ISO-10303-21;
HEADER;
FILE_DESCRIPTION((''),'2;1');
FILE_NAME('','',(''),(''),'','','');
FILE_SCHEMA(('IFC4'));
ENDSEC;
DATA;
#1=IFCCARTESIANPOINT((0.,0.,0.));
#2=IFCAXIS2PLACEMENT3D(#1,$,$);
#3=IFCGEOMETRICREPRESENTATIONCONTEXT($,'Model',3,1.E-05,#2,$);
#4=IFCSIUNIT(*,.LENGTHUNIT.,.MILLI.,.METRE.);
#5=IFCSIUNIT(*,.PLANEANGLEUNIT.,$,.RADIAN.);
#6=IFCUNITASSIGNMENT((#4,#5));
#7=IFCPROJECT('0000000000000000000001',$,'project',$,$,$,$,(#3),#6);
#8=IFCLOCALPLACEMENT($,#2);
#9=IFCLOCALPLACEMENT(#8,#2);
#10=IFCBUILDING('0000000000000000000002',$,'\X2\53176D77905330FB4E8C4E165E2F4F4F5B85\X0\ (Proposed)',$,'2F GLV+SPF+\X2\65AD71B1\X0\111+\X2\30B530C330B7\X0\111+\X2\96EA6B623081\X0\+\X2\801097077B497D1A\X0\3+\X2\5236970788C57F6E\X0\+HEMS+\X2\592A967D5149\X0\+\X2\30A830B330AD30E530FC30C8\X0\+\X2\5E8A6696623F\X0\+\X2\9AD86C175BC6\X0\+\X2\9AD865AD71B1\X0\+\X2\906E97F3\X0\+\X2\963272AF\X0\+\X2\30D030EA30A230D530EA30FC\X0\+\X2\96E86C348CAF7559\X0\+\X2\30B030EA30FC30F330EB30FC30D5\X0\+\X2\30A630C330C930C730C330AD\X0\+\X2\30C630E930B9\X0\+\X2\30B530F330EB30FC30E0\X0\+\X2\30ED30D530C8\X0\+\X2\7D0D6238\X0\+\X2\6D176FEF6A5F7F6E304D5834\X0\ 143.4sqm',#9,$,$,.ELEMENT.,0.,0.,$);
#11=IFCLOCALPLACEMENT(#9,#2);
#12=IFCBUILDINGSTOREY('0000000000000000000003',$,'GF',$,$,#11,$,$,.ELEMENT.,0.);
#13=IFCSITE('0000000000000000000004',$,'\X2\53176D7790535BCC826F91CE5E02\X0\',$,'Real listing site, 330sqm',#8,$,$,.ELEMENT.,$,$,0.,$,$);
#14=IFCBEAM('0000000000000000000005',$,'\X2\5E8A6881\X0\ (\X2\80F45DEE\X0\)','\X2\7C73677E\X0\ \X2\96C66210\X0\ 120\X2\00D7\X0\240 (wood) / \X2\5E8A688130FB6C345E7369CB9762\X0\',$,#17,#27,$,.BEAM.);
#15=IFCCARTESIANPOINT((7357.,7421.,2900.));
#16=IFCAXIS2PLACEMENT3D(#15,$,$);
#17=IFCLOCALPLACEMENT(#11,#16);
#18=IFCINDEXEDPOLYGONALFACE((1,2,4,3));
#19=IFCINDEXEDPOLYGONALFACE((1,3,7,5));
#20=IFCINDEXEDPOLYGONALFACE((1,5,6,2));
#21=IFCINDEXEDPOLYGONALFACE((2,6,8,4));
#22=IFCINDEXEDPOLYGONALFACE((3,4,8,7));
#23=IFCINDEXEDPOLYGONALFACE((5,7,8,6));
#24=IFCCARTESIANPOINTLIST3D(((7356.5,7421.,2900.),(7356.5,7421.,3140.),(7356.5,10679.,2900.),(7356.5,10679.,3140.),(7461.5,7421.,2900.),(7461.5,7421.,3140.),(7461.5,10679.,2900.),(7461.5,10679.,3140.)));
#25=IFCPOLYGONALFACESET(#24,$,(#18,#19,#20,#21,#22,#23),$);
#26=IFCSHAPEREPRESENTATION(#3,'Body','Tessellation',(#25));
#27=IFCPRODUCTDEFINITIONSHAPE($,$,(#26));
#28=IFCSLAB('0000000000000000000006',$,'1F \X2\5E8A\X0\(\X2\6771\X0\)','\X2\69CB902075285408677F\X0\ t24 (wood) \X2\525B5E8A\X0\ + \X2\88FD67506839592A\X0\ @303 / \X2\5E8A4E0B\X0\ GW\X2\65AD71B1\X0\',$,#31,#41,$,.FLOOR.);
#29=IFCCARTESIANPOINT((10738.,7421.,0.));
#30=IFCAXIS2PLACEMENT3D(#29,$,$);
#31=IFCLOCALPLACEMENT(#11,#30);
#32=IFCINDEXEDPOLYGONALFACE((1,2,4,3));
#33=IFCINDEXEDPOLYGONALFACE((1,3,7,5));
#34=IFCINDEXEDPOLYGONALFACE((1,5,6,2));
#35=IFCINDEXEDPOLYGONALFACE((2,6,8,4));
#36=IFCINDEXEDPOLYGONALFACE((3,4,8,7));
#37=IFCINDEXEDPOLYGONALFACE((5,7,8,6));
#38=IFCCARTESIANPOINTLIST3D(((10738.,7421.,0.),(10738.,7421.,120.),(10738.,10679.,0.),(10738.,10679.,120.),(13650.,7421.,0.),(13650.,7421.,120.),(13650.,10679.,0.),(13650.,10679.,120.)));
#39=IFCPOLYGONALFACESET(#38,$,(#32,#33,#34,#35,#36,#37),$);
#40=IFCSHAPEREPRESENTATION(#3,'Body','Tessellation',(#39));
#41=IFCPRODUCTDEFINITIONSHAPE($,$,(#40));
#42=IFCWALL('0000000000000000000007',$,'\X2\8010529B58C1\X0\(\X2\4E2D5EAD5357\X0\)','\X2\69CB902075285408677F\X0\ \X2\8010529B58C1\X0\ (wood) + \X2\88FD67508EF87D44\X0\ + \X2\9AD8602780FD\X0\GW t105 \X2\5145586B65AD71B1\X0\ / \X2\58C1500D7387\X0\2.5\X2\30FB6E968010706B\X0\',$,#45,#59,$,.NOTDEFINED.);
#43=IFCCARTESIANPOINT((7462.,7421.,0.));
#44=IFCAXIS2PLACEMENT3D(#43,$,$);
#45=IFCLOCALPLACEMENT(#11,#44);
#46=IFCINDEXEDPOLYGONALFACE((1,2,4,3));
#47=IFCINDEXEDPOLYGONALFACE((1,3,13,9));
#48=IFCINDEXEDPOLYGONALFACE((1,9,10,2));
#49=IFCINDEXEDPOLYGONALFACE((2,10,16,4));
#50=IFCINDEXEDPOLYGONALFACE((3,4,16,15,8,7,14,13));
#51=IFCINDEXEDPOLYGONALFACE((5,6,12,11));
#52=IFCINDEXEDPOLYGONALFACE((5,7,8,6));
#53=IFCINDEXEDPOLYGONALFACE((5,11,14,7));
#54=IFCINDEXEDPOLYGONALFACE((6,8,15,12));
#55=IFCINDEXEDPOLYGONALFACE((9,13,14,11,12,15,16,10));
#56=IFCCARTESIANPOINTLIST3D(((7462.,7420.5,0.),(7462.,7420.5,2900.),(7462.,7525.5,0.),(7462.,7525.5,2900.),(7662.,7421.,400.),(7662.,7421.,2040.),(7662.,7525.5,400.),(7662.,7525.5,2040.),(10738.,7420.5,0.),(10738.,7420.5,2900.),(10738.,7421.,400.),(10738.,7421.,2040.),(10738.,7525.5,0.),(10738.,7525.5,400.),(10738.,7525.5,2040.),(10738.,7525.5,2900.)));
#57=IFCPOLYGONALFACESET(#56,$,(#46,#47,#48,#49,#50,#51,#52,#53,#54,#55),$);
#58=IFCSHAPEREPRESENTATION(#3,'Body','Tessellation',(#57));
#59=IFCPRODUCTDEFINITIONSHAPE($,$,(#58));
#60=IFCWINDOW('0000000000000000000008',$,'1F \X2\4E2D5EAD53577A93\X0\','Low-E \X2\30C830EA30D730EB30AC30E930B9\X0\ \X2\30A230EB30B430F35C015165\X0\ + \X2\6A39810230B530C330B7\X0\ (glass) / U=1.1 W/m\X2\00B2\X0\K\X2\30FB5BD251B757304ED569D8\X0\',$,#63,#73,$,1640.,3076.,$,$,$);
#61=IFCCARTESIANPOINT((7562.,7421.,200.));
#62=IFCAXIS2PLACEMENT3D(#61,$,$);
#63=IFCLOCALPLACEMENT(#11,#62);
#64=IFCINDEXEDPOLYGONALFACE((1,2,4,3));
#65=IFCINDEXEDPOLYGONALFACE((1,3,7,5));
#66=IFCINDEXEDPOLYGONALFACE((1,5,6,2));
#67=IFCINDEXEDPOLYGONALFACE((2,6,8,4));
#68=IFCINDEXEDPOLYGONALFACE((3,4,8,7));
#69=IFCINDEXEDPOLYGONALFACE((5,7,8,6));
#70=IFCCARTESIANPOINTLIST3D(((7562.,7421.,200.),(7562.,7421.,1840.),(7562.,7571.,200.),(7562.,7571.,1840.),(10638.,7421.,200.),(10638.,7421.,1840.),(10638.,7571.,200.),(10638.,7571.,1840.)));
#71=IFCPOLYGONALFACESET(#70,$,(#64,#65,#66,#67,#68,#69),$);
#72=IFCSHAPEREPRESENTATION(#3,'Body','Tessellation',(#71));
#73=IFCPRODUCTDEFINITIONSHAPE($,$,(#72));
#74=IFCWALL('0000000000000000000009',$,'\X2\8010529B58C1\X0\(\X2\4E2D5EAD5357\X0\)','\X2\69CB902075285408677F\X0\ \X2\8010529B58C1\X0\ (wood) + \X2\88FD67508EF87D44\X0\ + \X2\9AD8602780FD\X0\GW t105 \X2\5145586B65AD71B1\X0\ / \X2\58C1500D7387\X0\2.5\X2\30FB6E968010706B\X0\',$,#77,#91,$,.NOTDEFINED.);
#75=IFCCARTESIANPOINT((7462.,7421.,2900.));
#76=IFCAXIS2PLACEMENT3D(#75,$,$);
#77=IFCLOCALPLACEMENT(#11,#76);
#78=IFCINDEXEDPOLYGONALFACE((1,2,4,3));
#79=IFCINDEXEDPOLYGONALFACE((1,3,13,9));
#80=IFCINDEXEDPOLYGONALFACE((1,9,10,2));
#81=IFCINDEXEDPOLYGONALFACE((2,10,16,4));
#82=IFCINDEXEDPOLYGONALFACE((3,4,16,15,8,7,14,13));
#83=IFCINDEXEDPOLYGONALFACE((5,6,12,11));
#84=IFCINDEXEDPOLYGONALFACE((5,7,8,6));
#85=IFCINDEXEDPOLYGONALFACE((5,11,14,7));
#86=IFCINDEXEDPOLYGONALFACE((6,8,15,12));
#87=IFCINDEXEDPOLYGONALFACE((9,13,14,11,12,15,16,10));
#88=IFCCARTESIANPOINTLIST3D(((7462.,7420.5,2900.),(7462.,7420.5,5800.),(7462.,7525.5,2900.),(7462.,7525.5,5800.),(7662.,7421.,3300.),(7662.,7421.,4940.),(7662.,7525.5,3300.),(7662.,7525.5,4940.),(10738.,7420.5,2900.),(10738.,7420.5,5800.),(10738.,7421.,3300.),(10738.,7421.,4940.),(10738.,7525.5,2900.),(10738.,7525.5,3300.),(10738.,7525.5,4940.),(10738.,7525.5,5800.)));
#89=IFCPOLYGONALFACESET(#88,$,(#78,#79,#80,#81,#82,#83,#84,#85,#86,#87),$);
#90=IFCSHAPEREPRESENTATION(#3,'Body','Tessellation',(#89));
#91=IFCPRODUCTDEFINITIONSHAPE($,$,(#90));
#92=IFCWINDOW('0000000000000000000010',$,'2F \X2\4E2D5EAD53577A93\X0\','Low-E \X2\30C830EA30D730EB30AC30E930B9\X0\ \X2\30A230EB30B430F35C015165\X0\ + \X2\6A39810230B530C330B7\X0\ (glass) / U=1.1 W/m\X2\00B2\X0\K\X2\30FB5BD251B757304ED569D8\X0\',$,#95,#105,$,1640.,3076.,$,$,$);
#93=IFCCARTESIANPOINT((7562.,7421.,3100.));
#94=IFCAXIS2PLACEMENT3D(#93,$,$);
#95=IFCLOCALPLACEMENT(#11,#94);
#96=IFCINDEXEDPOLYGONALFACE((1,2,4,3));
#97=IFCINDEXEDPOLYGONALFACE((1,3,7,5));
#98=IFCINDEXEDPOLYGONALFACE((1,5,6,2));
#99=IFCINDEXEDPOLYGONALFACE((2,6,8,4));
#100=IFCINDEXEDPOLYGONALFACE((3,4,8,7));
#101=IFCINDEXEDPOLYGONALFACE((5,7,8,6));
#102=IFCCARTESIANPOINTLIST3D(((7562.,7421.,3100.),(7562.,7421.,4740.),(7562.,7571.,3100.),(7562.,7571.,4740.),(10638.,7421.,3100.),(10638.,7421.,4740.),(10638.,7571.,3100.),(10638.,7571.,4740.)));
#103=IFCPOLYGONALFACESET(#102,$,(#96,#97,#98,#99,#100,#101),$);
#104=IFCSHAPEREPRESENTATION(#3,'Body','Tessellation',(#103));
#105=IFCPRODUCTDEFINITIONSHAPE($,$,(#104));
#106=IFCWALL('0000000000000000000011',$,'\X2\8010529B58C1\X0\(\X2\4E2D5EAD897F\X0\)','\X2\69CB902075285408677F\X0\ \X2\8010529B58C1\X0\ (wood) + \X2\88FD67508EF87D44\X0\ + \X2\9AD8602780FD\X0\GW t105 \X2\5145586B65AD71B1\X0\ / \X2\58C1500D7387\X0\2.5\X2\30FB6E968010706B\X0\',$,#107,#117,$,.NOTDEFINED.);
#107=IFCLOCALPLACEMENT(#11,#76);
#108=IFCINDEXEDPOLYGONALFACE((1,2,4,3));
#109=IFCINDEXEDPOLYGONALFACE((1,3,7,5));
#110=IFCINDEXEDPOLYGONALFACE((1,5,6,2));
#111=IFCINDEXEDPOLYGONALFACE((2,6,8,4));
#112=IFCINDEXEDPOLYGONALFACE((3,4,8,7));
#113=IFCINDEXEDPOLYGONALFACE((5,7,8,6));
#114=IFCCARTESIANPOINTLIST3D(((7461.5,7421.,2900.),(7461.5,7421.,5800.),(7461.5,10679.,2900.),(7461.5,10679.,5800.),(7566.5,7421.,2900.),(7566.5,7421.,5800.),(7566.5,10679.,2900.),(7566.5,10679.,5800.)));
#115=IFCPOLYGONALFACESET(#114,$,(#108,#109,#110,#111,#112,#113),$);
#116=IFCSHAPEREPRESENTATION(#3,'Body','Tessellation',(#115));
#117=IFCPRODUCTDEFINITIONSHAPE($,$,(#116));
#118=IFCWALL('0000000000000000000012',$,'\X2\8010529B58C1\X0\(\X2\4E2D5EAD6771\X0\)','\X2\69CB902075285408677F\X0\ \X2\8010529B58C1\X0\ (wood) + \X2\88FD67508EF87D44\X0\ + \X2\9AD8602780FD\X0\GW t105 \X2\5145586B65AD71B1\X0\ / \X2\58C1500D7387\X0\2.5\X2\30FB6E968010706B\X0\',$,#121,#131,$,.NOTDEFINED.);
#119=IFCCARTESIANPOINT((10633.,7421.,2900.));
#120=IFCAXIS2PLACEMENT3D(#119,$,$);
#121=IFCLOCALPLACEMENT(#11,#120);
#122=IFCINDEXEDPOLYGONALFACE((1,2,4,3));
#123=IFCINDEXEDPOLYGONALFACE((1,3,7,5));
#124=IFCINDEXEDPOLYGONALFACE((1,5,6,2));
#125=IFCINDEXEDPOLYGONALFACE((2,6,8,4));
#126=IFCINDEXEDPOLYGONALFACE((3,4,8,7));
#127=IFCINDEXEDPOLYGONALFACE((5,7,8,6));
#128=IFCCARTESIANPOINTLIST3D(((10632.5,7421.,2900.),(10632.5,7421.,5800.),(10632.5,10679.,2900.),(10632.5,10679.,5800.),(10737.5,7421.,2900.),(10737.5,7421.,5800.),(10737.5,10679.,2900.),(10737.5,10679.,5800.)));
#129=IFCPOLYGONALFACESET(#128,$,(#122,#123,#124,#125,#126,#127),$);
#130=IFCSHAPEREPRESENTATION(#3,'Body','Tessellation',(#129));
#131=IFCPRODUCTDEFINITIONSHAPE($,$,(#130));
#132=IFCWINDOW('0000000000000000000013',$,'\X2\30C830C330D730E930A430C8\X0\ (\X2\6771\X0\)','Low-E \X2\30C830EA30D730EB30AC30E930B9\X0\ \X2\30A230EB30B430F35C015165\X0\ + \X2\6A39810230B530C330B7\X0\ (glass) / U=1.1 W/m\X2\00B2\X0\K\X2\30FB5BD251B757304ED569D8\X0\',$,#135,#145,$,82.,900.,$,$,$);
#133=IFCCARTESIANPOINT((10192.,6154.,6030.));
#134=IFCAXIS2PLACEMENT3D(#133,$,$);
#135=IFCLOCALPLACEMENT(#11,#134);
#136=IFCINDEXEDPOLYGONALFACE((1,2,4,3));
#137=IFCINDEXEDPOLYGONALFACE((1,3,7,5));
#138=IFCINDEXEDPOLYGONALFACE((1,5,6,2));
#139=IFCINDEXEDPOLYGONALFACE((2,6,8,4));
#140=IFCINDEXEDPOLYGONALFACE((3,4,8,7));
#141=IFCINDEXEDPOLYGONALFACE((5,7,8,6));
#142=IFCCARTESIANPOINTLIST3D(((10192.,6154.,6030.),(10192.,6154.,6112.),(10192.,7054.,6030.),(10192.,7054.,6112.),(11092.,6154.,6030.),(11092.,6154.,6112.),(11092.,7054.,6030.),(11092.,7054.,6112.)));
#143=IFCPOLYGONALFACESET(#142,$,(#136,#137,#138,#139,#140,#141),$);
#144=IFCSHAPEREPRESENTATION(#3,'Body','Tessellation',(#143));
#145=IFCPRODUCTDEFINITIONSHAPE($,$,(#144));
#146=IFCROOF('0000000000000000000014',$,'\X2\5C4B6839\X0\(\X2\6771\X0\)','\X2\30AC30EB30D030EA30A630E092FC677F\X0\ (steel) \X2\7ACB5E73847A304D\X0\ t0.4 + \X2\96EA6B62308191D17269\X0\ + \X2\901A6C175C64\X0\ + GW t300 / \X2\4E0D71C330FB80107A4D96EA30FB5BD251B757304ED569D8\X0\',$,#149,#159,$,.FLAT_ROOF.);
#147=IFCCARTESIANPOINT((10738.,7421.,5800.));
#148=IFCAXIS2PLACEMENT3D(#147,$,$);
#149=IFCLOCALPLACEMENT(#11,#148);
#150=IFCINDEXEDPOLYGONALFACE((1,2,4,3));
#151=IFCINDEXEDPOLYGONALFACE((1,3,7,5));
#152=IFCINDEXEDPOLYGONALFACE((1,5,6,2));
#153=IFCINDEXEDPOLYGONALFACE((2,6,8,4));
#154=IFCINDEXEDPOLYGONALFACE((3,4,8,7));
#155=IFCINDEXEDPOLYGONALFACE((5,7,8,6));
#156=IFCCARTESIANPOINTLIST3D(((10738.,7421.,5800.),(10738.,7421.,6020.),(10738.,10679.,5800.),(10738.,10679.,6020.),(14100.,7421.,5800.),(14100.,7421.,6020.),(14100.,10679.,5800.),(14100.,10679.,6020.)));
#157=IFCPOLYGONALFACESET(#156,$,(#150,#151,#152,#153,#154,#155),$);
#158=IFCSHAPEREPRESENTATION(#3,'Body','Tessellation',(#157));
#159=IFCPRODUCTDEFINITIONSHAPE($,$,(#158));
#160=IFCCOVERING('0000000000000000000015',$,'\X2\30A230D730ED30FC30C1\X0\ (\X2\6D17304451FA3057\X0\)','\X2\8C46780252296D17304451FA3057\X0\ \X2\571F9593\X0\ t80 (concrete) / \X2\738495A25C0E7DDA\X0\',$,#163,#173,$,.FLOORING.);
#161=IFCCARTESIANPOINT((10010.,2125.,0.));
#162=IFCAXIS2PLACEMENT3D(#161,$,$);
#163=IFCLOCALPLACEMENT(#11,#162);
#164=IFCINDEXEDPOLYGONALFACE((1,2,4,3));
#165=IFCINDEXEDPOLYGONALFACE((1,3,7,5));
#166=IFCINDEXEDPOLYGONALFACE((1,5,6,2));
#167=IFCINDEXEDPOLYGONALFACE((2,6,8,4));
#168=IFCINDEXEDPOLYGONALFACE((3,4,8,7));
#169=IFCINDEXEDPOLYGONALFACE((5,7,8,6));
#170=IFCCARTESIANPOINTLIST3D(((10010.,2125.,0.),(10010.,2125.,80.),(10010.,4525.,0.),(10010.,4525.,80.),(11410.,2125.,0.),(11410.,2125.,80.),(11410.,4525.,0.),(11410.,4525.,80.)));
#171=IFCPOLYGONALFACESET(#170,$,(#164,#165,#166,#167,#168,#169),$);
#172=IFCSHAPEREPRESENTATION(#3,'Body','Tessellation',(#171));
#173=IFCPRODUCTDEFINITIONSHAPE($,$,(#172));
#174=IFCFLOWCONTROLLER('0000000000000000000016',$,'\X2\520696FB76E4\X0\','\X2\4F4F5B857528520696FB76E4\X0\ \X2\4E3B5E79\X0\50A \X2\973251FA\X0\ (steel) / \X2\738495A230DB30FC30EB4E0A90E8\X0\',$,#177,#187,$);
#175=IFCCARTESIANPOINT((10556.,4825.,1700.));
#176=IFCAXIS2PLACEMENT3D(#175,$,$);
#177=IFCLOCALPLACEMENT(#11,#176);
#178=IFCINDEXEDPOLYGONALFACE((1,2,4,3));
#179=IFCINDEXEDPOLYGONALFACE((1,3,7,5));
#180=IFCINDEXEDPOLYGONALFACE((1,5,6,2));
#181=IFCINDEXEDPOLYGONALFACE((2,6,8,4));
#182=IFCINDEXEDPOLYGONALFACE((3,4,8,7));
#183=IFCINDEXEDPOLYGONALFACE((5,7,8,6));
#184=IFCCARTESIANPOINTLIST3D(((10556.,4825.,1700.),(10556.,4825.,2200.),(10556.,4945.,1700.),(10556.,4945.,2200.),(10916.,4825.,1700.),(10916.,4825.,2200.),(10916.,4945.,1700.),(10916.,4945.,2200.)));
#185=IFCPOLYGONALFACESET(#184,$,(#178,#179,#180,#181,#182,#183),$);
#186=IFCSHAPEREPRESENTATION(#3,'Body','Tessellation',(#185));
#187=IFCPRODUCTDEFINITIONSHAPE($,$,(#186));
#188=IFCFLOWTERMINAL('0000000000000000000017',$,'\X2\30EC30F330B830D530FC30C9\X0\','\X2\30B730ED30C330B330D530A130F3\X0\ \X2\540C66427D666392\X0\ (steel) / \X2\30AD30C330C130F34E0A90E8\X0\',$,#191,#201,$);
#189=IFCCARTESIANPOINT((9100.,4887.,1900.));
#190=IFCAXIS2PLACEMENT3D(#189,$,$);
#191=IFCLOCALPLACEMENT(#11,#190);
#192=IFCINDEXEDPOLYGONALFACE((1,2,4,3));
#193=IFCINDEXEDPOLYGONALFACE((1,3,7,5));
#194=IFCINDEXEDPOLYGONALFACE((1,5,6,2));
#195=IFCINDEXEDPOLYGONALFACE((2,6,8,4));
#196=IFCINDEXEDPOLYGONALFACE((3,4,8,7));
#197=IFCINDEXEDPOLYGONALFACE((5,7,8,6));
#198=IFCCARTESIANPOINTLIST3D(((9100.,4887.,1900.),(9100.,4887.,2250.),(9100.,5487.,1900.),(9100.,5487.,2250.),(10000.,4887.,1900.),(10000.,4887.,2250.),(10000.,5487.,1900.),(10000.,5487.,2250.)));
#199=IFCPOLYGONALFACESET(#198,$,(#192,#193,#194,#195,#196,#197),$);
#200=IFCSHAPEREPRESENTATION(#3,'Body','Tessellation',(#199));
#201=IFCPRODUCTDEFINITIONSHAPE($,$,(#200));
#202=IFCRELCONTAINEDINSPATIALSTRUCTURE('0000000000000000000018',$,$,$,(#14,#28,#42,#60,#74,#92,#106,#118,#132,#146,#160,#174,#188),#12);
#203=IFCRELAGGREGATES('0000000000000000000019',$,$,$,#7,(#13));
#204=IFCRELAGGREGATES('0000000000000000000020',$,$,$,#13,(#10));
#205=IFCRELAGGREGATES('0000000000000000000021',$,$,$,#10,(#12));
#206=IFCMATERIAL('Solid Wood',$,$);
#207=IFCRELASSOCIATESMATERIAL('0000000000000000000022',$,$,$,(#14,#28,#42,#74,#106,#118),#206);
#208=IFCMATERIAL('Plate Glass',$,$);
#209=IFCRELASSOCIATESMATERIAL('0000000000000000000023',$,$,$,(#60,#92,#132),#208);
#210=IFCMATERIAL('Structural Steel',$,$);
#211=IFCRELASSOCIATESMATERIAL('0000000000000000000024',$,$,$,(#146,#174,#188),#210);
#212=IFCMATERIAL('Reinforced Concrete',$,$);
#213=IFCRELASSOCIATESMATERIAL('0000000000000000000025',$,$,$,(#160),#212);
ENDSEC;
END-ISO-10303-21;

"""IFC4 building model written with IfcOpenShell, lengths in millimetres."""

from ifc_helpers import new_model, si_unit, frame, frame_2d, origin, place, context, project, spatial, rectangle, extrude, material, element, fill, save


model = new_model("IFC4")

# Units and contexts
model_context = context("Model", 3, precision=1e-05, world=origin())
ifc_project = project(units=[si_unit("LENGTHUNIT", "METRE", prefix="MILLI"), si_unit("PLANEANGLEUNIT", "RADIAN")], contexts=[model_context])

# Site, building, storey
site_placement = place(None, origin())
site = spatial("IfcSite", under=ifc_project, at=site_placement, Name="北海道富良野市", ObjectType="Real listing site, 330sqm", CompositionType="ELEMENT", RefElevation=0.0)
building_placement = place(site_placement, origin())
building = spatial("IfcBuilding", under=site, at=building_placement, Name="北海道・二世帯住宅 (Proposed)", ObjectType="2F GLV+SPF+断熱111+サッシ111+雪止め+耐震等級3+制震装置+HEMS+太陽光+エコキュート+床暖房+高気密+高断熱+遮音+防犯+バリアフリー+雨水貯留+グリーンルーフ+ウッドデッキ+テラス+サンルーム+ロフト+納戸+洗濯機置き場 143.4sqm", CompositionType="ELEMENT", ElevationOfRefHeight=0.0, ElevationOfTerrain=0.0)
storey_placement = place(building_placement, origin())
storey = spatial("IfcBuildingStorey", under=building, at=storey_placement, Name="GF", CompositionType="ELEMENT", Elevation=0.0)

# Shared definitions
ifc_material_1 = material(Name="Solid Wood")

# Beam
beam_placement = place(storey_placement, frame((7357.0, 7421.0, 2900.0)))
element("IfcBeam", 1, at=beam_placement, inside=storey, material=ifc_material_1, Name="床梁 (胴差)", Description="米松 集成 120×240 (wood) / 床梁・水平構面", PredefinedType="BEAM", context=model_context, shape_type="SweptSolid", body=[
    extrude(rectangle(XDim=105.0, YDim=3258.0, at=frame_2d((52.0, 1629.0))), frame((7357.0, 7421.0, 2900.0)), (0.0, 0.0, 1.0), 240.0),
])

# Slab
slab_placement = place(storey_placement, frame((10738.0, 7421.0, 0.0)))
element("IfcSlab", 2, at=slab_placement, inside=storey, material=ifc_material_1, Name="1F 床(東)", Description="構造用合板 t24 (wood) 剛床 + 製材根太 @303 / 床下 GW断熱", PredefinedType="FLOOR", context=model_context, shape_type="SweptSolid", body=[
    extrude(rectangle(XDim=2912.0, YDim=3258.0, at=frame_2d((1456.0, 1629.0))), frame((10738.0, 7421.0, 0.0)), (0.0, 0.0, 1.0), 120.0),
])

# Wall, opening, window
wall_1_placement = place(storey_placement, frame((7462.0, 7421.0, 0.0)))
wall_1 = element("IfcWall", 3, at=wall_1_placement, inside=storey, material=ifc_material_1, Name="耐力壁(中庭南)", Description="構造用合板 耐力壁 (wood) + 製材軸組 + 高性能GW t105 充填断熱 / 壁倍率2.5・準耐火", PredefinedType="NOTDEFINED", context=model_context, shape_type="SweptSolid", body=[
    extrude(rectangle(XDim=3276.0, YDim=105.0, at=frame_2d((1638.0, 52.0))), frame((7462.0, 7421.0, 0.0)), (0.0, 0.0, 1.0), 2900.0),
])
opening_1_placement = place(storey_placement, frame((7562.0, 7421.0, 200.0)))
opening_1 = element("IfcOpeningElement", 4, at=opening_1_placement, cuts=wall_1, PredefinedType="NOTDEFINED", context=model_context, shape_type="SweptSolid", body=[
    extrude(rectangle(XDim=3076.0, YDim=150.0, at=frame_2d((1538.0, 75.0))), frame((7562.0, 7421.0, 200.0)), (0.0, 0.0, 1.0), 1640.0),
])
ifc_material_2 = material(Name="Plate Glass")
window_1_placement = place(storey_placement, frame((7562.0, 7421.0, 200.0)))
window_1 = element("IfcWindow", 5, at=window_1_placement, inside=storey, material=ifc_material_2, Name="1F 中庭南窓", Description="Low-E トリプルガラス アルゴン封入 + 樹脂サッシ (glass) / U=1.1 W/m²K・寒冷地仕様", OverallHeight=1640.0, OverallWidth=3076.0, context=model_context, shape_type="SweptSolid", body=[
    extrude(rectangle(XDim=3076.0, YDim=150.0, at=frame_2d((1538.0, 75.0))), frame((7562.0, 7421.0, 200.0)), (0.0, 0.0, 1.0), 1640.0),
])
fill(opening_1, window_1)

# Wall, opening, window
wall_2_placement = place(storey_placement, frame((7462.0, 7421.0, 2900.0)))
wall_2 = element("IfcWall", 6, at=wall_2_placement, inside=storey, material=ifc_material_1, Name="耐力壁(中庭南)", Description="構造用合板 耐力壁 (wood) + 製材軸組 + 高性能GW t105 充填断熱 / 壁倍率2.5・準耐火", PredefinedType="NOTDEFINED", context=model_context, shape_type="SweptSolid", body=[
    extrude(rectangle(XDim=3276.0, YDim=105.0, at=frame_2d((1638.0, 52.0))), frame((7462.0, 7421.0, 2900.0)), (0.0, 0.0, 1.0), 2900.0),
])
opening_2_placement = place(storey_placement, frame((7562.0, 7421.0, 3100.0)))
opening_2 = element("IfcOpeningElement", 7, at=opening_2_placement, cuts=wall_2, PredefinedType="NOTDEFINED", context=model_context, shape_type="SweptSolid", body=[
    extrude(rectangle(XDim=3076.0, YDim=150.0, at=frame_2d((1538.0, 75.0))), frame((7562.0, 7421.0, 3100.0)), (0.0, 0.0, 1.0), 1640.0),
])
window_2_placement = place(storey_placement, frame((7562.0, 7421.0, 3100.0)))
window_2 = element("IfcWindow", 8, at=window_2_placement, inside=storey, material=ifc_material_2, Name="2F 中庭南窓", Description="Low-E トリプルガラス アルゴン封入 + 樹脂サッシ (glass) / U=1.1 W/m²K・寒冷地仕様", OverallHeight=1640.0, OverallWidth=3076.0, context=model_context, shape_type="SweptSolid", body=[
    extrude(rectangle(XDim=3076.0, YDim=150.0, at=frame_2d((1538.0, 75.0))), frame((7562.0, 7421.0, 3100.0)), (0.0, 0.0, 1.0), 1640.0),
])
fill(opening_2, window_2)

# Walls
wall_3_placement = place(storey_placement, frame((7462.0, 7421.0, 2900.0)))
element("IfcWall", 9, at=wall_3_placement, inside=storey, material=ifc_material_1, Name="耐力壁(中庭西)", Description="構造用合板 耐力壁 (wood) + 製材軸組 + 高性能GW t105 充填断熱 / 壁倍率2.5・準耐火", PredefinedType="NOTDEFINED", context=model_context, shape_type="SweptSolid", body=[
    extrude(rectangle(XDim=105.0, YDim=3258.0, at=frame_2d((52.0, 1629.0))), frame((7462.0, 7421.0, 2900.0)), (0.0, 0.0, 1.0), 2900.0),
])
wall_4_placement = place(storey_placement, frame((10633.0, 7421.0, 2900.0)))
element("IfcWall", 10, at=wall_4_placement, inside=storey, material=ifc_material_1, Name="耐力壁(中庭東)", Description="構造用合板 耐力壁 (wood) + 製材軸組 + 高性能GW t105 充填断熱 / 壁倍率2.5・準耐火", PredefinedType="NOTDEFINED", context=model_context, shape_type="SweptSolid", body=[
    extrude(rectangle(XDim=105.0, YDim=3258.0, at=frame_2d((52.0, 1629.0))), frame((10633.0, 7421.0, 2900.0)), (0.0, 0.0, 1.0), 2900.0),
])

# Window
window_3_placement = place(storey_placement, frame((10192.0, 6154.0, 6030.0)))
element("IfcWindow", 11, at=window_3_placement, inside=storey, material=ifc_material_2, Name="トップライト (東)", Description="Low-E トリプルガラス アルゴン封入 + 樹脂サッシ (glass) / U=1.1 W/m²K・寒冷地仕様", OverallHeight=82.0, OverallWidth=900.0, context=model_context, shape_type="SweptSolid", body=[
    extrude(rectangle(XDim=900.0, YDim=900.0, at=frame_2d((450.0, 450.0))), frame((10192.0, 6154.0, 6030.0)), (0.0, 0.0, 1.0), 82.0),
])

# Roof
ifc_material_3 = material(Name="Structural Steel")
roof_placement = place(storey_placement, frame((10738.0, 7421.0, 5800.0)))
element("IfcRoof", 12, at=roof_placement, inside=storey, material=ifc_material_3, Name="屋根(東)", Description="ガルバリウム鋼板 (steel) 立平葺き t0.4 + 雪止め金物 + 通気層 + GW t300 / 不燃・耐積雪・寒冷地仕様", PredefinedType="FLAT_ROOF", context=model_context, shape_type="SweptSolid", body=[
    extrude(rectangle(XDim=3362.0, YDim=3258.0, at=frame_2d((1681.0, 1629.0))), frame((10738.0, 7421.0, 5800.0)), (0.0, 0.0, 1.0), 220.0),
])

# Covering
ifc_material_4 = material(Name="Reinforced Concrete")
covering_placement = place(storey_placement, frame((10010.0, 2125.0, 0.0)))
element("IfcCovering", 13, at=covering_placement, inside=storey, material=ifc_material_4, Name="アプローチ (洗い出し)", Description="豆砂利洗い出し 土間 t80 (concrete) / 玄関導線", PredefinedType="FLOORING", context=model_context, shape_type="SweptSolid", body=[
    extrude(rectangle(XDim=1400.0, YDim=2400.0, at=frame_2d((700.0, 1200.0))), frame((10010.0, 2125.0, 0.0)), (0.0, 0.0, 1.0), 80.0),
])

# Flow controller
flow_controller_placement = place(storey_placement, frame((10556.0, 4825.0, 1700.0)))
element("IfcFlowController", 14, at=flow_controller_placement, inside=storey, material=ifc_material_3, Name="分電盤", Description="住宅用分電盤 主幹50A 露出 (steel) / 玄関ホール上部", context=model_context, shape_type="SweptSolid", body=[
    extrude(rectangle(XDim=360.0, YDim=120.0, at=frame_2d((180.0, 60.0))), frame((10556.0, 4825.0, 1700.0)), (0.0, 0.0, 1.0), 500.0),
])

# Flow terminal
flow_terminal_1_placement = place(storey_placement, frame((9100.0, 4887.0, 1900.0)))
element("IfcFlowTerminal", 15, at=flow_terminal_1_placement, inside=storey, material=ifc_material_3, Name="レンジフード", Description="シロッコファン 同時給排 (steel) / キッチン上部", context=model_context, shape_type="SweptSolid", body=[
    extrude(rectangle(XDim=900.0, YDim=600.0, at=frame_2d((450.0, 300.0))), frame((9100.0, 4887.0, 1900.0)), (0.0, 0.0, 1.0), 350.0),
])

save(model, "model.ifc")
